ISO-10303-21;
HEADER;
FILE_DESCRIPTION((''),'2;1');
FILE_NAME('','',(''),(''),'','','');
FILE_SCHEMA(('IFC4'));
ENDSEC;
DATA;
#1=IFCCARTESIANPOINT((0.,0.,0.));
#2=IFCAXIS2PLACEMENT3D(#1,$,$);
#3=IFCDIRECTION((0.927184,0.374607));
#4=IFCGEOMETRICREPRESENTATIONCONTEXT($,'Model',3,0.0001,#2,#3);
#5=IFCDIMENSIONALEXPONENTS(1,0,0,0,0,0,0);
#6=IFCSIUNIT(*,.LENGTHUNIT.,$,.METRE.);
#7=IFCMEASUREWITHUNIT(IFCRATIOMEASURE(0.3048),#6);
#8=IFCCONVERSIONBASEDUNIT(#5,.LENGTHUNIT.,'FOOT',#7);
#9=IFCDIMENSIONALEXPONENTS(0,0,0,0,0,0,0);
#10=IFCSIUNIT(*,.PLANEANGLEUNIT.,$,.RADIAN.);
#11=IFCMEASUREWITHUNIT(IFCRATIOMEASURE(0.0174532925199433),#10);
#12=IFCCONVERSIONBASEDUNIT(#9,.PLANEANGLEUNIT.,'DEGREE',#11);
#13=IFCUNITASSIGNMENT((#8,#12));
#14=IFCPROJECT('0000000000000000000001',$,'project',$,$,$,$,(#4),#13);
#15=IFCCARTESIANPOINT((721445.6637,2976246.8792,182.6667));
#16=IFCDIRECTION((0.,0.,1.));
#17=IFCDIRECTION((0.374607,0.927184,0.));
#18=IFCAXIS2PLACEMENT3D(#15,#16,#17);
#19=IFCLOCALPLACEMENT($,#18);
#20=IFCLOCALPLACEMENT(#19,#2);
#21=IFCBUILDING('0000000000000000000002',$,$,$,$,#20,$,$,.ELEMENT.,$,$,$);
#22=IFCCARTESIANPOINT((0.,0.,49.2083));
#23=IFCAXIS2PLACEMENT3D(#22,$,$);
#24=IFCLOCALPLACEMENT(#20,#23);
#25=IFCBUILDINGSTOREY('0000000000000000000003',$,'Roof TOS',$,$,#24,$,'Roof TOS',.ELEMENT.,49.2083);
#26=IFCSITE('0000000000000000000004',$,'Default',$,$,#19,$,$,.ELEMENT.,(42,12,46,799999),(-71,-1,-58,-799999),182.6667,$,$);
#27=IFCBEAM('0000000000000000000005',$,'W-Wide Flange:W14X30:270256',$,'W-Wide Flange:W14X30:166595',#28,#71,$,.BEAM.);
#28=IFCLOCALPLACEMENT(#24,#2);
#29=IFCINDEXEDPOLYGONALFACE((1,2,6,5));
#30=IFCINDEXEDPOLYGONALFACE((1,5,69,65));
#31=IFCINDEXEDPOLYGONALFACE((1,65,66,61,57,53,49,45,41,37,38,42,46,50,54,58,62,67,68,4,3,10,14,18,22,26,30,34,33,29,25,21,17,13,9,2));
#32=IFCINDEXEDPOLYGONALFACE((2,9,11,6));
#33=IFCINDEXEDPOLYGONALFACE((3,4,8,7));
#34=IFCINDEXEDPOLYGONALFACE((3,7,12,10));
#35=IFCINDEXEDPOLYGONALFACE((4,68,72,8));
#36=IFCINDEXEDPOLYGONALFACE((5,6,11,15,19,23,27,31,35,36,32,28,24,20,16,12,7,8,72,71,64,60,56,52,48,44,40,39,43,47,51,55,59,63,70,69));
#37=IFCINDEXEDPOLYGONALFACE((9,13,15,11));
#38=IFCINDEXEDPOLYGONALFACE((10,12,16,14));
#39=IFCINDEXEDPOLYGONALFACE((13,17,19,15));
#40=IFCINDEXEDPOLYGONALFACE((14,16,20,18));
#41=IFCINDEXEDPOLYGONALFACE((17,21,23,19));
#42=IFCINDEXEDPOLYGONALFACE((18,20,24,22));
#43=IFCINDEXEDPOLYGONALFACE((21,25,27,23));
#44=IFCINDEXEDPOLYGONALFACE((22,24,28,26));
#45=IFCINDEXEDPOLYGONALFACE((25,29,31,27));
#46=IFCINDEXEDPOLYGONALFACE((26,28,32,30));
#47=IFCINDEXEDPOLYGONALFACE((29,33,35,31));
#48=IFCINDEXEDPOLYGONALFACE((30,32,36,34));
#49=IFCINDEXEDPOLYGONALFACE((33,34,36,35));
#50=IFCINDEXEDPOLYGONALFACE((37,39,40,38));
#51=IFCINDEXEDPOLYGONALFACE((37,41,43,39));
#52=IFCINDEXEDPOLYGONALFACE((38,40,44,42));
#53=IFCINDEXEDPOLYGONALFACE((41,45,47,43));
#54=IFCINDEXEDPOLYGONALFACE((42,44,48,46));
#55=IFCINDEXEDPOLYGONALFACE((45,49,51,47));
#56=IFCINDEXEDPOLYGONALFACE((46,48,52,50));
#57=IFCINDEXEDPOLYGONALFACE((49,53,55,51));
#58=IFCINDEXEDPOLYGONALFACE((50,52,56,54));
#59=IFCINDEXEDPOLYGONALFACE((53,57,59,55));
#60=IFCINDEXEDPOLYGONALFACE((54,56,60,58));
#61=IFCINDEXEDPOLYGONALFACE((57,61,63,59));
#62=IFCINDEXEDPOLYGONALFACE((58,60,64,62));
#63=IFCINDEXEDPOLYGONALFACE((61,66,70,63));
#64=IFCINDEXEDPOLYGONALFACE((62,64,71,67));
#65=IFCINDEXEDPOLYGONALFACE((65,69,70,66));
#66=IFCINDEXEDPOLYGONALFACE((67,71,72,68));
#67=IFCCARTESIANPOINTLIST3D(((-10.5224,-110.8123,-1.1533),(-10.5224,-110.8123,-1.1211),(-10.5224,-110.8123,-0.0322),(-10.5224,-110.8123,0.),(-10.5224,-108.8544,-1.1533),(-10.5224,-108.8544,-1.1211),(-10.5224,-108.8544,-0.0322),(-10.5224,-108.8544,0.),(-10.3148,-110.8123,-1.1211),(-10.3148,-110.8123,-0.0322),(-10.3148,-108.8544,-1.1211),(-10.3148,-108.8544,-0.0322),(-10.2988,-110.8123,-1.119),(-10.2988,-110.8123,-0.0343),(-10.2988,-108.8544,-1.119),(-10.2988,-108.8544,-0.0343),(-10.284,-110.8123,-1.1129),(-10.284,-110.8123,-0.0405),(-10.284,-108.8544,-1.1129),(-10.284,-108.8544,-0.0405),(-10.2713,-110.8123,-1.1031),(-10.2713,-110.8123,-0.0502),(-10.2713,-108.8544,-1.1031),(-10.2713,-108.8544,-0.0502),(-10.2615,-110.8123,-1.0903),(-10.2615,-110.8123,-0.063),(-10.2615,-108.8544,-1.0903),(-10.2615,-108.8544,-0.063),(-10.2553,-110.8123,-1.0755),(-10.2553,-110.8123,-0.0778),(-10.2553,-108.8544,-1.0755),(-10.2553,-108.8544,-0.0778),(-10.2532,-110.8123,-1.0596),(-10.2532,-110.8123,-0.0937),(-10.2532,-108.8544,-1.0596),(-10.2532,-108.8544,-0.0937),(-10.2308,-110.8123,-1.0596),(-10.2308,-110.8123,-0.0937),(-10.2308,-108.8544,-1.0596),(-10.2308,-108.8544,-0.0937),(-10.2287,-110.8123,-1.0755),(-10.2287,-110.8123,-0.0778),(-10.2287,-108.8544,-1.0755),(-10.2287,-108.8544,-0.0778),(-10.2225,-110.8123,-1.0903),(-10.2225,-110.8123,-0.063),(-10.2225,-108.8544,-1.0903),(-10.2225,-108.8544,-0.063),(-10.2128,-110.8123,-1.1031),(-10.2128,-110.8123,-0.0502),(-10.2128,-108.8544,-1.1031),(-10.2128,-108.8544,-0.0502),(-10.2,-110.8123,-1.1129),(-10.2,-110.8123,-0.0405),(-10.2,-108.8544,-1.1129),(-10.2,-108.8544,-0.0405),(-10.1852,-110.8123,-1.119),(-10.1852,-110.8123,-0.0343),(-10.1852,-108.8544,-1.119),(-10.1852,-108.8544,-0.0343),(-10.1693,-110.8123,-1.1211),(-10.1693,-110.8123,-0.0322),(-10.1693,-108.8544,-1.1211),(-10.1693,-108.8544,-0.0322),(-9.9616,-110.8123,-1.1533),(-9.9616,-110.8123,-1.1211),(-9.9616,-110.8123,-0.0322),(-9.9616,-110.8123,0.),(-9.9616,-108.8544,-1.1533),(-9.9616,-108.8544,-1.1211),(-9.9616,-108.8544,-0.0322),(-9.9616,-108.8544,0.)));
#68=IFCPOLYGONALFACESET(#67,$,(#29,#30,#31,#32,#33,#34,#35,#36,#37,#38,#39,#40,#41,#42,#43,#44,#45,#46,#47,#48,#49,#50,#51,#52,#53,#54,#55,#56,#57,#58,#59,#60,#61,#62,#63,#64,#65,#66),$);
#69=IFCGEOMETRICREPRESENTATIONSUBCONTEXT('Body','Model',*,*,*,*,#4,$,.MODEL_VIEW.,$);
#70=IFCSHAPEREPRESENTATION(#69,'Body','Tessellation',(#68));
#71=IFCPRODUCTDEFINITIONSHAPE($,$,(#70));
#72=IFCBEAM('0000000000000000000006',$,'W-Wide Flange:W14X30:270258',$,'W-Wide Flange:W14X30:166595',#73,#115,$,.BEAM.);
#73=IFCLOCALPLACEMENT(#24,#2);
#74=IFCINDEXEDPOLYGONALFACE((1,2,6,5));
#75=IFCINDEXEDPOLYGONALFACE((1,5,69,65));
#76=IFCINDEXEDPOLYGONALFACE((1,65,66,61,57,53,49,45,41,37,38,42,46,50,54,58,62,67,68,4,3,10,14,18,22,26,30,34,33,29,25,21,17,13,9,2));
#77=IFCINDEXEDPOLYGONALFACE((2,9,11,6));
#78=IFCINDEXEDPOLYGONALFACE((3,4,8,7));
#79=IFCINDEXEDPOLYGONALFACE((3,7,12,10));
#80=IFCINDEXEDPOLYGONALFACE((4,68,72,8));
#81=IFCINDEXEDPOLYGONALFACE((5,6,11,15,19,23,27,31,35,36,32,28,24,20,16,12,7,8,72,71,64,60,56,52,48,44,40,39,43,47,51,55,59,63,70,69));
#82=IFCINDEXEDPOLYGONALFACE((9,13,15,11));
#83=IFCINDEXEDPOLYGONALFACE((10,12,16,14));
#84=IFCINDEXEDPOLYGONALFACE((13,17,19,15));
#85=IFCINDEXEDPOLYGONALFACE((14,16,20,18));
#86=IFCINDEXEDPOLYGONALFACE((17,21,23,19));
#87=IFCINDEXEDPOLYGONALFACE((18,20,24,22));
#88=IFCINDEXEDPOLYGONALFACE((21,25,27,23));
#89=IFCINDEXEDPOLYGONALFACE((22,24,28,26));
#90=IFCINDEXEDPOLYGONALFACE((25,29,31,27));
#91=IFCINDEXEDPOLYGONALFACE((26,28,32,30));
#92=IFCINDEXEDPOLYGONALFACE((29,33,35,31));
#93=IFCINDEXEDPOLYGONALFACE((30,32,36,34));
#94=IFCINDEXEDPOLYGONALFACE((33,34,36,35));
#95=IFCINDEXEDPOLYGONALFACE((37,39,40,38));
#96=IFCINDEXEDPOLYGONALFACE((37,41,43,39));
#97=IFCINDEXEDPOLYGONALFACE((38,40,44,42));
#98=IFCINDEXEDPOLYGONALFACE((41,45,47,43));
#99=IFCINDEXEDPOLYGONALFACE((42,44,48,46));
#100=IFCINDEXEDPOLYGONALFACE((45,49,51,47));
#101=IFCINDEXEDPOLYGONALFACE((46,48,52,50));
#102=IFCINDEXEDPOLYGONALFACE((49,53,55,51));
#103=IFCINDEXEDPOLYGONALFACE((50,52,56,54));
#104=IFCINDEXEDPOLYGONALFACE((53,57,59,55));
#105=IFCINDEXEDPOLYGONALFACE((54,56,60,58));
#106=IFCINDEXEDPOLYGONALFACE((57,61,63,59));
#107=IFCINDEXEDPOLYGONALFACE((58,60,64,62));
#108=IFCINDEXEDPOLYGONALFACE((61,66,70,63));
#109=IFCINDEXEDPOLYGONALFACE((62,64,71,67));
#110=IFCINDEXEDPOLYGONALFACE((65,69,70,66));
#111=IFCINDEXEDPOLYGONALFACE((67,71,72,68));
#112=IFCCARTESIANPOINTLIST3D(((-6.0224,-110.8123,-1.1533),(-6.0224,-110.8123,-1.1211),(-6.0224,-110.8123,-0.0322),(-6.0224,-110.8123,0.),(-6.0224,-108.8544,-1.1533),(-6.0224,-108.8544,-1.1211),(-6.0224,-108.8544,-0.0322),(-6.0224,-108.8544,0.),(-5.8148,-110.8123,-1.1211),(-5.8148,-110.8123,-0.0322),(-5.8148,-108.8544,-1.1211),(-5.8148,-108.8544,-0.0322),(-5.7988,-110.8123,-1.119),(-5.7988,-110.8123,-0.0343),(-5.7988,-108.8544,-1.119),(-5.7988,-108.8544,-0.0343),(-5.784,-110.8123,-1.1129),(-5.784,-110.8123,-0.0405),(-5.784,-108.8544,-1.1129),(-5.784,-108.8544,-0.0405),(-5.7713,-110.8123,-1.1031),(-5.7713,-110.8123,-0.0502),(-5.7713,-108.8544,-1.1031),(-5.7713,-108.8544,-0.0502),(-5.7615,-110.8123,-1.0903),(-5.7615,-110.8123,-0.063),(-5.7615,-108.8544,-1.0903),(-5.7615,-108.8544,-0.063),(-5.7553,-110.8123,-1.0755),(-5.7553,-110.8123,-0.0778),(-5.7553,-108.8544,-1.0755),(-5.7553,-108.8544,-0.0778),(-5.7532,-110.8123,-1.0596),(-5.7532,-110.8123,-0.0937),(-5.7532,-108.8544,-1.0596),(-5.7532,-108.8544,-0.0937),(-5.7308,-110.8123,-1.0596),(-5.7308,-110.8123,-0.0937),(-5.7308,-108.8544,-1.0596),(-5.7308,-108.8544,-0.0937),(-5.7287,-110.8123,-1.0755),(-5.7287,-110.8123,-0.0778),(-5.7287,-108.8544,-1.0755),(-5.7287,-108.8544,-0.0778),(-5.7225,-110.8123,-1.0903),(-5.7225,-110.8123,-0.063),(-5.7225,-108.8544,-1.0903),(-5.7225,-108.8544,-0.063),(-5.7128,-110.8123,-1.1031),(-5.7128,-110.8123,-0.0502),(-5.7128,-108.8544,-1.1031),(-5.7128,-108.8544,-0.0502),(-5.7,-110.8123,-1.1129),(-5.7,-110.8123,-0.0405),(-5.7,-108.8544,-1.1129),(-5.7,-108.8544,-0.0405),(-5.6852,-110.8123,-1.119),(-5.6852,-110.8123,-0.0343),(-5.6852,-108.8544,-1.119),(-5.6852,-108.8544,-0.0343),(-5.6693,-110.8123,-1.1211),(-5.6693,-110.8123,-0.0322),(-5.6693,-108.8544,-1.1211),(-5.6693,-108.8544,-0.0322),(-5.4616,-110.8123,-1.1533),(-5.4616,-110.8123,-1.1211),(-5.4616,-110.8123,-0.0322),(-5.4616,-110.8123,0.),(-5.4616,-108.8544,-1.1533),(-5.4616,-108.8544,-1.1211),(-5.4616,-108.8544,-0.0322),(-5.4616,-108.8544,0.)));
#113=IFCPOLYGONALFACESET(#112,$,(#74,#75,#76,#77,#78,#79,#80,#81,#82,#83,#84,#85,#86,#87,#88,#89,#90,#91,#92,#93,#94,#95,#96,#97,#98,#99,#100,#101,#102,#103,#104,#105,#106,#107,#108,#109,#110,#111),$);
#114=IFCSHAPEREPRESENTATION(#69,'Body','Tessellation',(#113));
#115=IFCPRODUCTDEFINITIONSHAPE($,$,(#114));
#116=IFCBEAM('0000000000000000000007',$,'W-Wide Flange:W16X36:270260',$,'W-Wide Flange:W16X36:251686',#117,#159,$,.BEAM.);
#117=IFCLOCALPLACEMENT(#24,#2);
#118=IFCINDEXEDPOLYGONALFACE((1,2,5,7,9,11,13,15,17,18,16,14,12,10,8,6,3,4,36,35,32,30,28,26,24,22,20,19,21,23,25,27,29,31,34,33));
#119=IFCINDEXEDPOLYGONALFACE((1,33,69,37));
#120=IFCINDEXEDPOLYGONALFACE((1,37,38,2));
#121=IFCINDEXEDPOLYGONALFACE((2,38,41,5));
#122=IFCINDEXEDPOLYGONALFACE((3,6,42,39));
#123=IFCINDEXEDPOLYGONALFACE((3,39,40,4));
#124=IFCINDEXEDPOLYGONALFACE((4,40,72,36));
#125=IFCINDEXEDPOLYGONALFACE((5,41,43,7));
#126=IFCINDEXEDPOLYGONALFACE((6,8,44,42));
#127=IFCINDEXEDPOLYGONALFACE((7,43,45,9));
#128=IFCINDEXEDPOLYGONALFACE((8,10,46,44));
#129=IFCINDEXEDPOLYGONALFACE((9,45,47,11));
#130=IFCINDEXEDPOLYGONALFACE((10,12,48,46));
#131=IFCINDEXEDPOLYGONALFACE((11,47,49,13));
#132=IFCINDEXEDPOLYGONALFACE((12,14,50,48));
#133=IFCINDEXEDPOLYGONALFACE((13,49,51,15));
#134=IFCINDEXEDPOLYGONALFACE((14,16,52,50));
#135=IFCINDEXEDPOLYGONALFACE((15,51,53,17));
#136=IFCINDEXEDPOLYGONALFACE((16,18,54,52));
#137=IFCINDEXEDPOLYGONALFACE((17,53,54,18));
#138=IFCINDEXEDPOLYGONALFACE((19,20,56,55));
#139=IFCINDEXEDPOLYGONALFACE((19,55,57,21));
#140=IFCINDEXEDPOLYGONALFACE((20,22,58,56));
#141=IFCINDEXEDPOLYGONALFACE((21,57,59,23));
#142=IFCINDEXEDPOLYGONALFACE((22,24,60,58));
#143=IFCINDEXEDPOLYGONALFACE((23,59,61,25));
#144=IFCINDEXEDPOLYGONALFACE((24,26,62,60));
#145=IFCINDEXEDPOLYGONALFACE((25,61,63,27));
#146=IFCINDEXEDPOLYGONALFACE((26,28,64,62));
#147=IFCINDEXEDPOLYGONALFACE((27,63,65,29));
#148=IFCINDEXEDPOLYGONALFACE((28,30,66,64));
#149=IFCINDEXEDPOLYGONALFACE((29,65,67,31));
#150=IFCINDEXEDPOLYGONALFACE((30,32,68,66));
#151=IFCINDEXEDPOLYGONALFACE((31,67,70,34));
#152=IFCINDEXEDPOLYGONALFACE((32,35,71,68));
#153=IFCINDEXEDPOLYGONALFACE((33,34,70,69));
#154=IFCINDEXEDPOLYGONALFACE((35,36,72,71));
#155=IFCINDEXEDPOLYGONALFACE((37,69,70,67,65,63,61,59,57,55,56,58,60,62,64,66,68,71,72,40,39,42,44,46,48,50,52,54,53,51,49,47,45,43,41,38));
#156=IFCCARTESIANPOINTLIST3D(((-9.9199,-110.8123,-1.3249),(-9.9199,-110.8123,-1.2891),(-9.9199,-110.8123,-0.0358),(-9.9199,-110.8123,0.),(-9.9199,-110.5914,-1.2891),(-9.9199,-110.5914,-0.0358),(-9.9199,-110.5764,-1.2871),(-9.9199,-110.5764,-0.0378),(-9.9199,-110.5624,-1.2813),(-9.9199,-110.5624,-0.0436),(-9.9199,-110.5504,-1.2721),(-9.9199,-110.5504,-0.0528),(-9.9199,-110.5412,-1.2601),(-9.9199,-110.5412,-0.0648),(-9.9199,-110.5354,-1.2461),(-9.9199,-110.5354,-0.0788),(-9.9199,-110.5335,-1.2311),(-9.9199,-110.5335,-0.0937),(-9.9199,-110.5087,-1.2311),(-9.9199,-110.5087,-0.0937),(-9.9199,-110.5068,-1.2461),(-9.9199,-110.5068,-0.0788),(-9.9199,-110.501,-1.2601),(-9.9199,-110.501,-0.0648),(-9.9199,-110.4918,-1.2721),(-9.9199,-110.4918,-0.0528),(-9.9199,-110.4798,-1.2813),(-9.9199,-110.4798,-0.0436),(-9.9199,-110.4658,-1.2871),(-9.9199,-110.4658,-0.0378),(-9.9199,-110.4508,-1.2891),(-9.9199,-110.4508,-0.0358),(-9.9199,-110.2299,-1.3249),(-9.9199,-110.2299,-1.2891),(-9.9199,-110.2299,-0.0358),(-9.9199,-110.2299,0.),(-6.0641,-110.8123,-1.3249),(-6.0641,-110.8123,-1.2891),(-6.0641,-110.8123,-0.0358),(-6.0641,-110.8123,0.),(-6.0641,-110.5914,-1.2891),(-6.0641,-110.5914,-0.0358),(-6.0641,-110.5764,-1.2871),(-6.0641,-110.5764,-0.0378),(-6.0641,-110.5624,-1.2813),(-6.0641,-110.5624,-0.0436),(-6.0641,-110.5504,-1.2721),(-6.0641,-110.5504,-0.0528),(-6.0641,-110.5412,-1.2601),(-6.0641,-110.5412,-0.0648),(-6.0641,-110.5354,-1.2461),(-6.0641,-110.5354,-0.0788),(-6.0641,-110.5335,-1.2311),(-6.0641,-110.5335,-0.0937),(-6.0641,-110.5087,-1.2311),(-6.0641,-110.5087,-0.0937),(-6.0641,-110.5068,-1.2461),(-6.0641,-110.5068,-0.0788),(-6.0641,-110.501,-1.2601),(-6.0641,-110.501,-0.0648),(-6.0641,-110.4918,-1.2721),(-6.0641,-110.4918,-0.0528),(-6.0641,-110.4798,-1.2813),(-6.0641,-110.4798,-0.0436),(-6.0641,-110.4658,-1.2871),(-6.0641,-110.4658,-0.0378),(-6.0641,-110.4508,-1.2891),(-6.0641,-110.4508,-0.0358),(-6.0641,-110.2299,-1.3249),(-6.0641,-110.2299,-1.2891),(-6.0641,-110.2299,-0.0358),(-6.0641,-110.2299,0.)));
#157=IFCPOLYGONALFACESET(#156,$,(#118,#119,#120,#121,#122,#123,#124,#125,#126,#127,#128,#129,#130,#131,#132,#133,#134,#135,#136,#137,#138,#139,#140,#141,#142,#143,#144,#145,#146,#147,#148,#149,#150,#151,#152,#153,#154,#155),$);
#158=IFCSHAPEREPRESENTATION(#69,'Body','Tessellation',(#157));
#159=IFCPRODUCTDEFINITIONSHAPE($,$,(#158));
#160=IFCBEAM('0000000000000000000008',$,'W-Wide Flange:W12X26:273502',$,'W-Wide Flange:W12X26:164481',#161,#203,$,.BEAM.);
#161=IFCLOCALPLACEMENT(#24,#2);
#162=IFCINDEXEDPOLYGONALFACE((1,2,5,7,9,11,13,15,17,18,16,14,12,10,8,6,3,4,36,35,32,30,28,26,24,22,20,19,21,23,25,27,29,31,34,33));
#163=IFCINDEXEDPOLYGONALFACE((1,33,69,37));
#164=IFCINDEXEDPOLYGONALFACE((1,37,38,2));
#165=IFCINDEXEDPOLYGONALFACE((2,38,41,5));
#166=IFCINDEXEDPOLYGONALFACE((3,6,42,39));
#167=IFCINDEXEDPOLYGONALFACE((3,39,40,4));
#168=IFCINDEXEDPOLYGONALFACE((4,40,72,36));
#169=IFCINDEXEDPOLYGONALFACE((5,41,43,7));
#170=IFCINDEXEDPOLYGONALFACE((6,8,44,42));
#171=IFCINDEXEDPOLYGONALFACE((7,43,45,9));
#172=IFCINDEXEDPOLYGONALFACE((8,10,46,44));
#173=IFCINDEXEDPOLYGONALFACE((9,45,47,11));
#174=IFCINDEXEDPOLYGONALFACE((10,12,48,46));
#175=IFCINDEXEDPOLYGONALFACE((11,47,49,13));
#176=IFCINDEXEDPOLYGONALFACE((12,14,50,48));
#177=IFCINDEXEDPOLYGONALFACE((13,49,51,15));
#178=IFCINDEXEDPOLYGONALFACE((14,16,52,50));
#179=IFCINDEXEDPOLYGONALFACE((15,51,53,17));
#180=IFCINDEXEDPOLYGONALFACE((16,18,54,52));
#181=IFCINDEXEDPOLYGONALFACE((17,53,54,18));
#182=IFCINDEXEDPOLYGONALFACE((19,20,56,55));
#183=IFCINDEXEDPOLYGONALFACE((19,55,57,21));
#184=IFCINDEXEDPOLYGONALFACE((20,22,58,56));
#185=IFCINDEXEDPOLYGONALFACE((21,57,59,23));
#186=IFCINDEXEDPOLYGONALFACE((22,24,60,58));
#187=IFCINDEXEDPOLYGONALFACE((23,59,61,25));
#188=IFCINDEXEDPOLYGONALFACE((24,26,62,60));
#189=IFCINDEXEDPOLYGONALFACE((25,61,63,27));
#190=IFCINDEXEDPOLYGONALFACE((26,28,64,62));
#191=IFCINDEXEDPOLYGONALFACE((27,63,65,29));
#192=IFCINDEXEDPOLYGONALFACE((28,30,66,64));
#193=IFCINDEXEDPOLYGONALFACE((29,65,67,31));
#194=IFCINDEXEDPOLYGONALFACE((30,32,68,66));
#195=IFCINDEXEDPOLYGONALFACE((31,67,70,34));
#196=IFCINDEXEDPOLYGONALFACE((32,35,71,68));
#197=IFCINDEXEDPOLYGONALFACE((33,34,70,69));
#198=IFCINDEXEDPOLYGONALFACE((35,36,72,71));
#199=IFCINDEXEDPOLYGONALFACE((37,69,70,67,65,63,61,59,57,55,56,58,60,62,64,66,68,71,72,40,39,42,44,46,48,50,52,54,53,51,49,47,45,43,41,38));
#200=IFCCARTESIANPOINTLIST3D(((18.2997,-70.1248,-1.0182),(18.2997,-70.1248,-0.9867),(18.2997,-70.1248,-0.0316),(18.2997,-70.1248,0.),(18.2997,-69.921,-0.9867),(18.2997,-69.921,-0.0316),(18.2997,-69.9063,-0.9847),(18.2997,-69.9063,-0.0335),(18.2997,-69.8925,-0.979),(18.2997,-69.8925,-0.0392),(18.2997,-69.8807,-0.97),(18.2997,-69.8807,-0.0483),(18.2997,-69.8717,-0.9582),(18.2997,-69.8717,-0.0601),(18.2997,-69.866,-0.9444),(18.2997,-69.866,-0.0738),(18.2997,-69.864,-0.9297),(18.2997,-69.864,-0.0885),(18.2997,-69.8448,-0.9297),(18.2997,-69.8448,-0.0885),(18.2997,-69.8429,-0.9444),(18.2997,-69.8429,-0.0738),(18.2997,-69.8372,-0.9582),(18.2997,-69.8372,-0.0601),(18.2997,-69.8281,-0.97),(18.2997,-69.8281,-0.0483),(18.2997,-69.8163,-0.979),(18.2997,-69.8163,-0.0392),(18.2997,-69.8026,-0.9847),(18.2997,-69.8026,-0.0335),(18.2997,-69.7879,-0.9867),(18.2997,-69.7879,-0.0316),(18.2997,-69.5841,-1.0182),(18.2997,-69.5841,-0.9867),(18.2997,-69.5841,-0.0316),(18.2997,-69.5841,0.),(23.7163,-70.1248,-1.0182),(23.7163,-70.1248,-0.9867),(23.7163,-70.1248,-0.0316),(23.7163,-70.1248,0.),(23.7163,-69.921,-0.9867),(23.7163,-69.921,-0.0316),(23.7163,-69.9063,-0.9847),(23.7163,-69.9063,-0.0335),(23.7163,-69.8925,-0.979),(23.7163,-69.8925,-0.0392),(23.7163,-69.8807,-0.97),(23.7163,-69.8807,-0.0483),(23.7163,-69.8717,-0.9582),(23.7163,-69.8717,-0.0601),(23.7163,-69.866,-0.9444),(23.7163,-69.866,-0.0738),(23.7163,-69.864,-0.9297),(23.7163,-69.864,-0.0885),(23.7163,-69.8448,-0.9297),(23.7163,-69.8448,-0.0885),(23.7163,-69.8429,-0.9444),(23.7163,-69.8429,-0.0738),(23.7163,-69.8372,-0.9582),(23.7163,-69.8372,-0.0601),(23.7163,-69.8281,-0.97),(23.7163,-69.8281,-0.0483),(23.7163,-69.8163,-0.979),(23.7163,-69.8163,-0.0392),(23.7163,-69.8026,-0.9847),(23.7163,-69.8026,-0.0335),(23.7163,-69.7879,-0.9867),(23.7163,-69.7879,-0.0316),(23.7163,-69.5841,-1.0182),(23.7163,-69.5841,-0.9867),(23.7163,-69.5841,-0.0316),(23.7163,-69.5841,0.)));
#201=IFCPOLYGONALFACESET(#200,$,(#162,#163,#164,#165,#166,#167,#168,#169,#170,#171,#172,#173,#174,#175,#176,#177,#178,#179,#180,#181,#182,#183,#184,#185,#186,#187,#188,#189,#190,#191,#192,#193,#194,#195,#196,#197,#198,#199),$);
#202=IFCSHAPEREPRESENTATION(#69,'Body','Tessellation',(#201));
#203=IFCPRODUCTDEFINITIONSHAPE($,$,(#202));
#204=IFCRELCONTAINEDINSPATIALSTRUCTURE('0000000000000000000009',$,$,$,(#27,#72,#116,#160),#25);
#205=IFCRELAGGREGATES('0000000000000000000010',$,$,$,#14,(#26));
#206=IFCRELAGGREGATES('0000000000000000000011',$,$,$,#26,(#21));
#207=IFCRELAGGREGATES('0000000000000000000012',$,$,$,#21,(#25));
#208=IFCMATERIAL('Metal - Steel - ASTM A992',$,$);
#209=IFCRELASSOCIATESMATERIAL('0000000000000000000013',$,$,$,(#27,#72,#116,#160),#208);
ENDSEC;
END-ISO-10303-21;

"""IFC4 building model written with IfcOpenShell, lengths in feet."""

from ifc_helpers import new_model, entity, si_unit, converted_unit, direction, frame, frame_2d, origin, place, context, subcontext, project, spatial, i_section, extrude, material, element, save


model = new_model("IFC4")

# Units and contexts
model_context = context("Model", 3, precision=0.0001, world=origin(), true_north=direction((0.927184, 0.374607)))
body_context = subcontext(model_context, "Body", "Model", "MODEL_VIEW")
ifc_project = project(units=[converted_unit("LENGTHUNIT", "FOOT", entity("IfcRatioMeasure", 0.3048), si_unit("LENGTHUNIT", "METRE"), dimensions=[1, 0, 0, 0, 0, 0, 0]), converted_unit("PLANEANGLEUNIT", "DEGREE", entity("IfcRatioMeasure", 0.0174532925199433), si_unit("PLANEANGLEUNIT", "RADIAN"), dimensions=[0, 0, 0, 0, 0, 0, 0])], contexts=[model_context])

# Site, building, storey
site_placement = place(None, frame((721445.6637, 2976246.8792, 182.6667), z_axis=(0.0, 0.0, 1.0), x_axis=(0.374607, 0.927184, 0.0)))
site = spatial("IfcSite", under=ifc_project, at=site_placement, Name="Default", CompositionType="ELEMENT", RefLatitude=(42, 12, 46, 799999), RefLongitude=(-71, -1, -58, -799999), RefElevation=182.6667)
building_placement = place(site_placement, origin())
building = spatial("IfcBuilding", under=site, at=building_placement, CompositionType="ELEMENT")
storey_placement = place(building_placement, frame((0.0, 0.0, 49.2083)))
storey = spatial("IfcBuildingStorey", under=building, at=storey_placement, Name="Roof TOS", LongName="Roof TOS", CompositionType="ELEMENT", Elevation=49.2083)

# Beams
ifc_material = material(Name="Metal - Steel - ASTM A992")
beam_1_placement = place(storey_placement, frame((-10.242, -108.5211, 0.0), z_axis=(0.0, 0.0, 1.0), x_axis=(0.0, -1.0, 0.0)))
element("IfcBeam", 1, at=beam_1_placement, inside=storey, material=ifc_material, Name="W-Wide Flange:W14X30:270256", ObjectType="W-Wide Flange:W14X30:166595", PredefinedType="BEAM", context=body_context, shape_type="SweptSolid", body=[
    extrude(i_section(OverallWidth=0.5609, OverallDepth=1.1533, WebThickness=0.0225, FlangeThickness=0.0322, FilletRadius=0.0615, at=frame_2d((0.0, 0.0), x_axis=(0.0, 1.0))), frame((0.3333, 0.0, -0.5767), z_axis=(1.0, 0.0, 0.0), x_axis=(0.0, 0.0, -1.0)), (0.0, 0.0, 1.0), 1.9578),
])
beam_2_placement = place(storey_placement, frame((-5.742, -108.5211, 0.0), z_axis=(0.0, 0.0, 1.0), x_axis=(0.0, -1.0, 0.0)))
element("IfcBeam", 2, at=beam_2_placement, inside=storey, material=ifc_material, Name="W-Wide Flange:W14X30:270258", ObjectType="W-Wide Flange:W14X30:166595", PredefinedType="BEAM", context=body_context, shape_type="SweptSolid", body=[
    extrude(i_section(OverallWidth=0.5609, OverallDepth=1.1533, WebThickness=0.0225, FlangeThickness=0.0322, FilletRadius=0.0615, at=frame_2d((0.0, 0.0), x_axis=(0.0, 1.0))), frame((0.3333, 0.0, -0.5767), z_axis=(1.0, 0.0, 0.0), x_axis=(0.0, 0.0, -1.0)), (0.0, 0.0, 1.0), 1.9578),
])
beam_3_placement = place(storey_placement, frame((-10.242, -110.5211, 0.0)))
element("IfcBeam", 3, at=beam_3_placement, inside=storey, material=ifc_material, Name="W-Wide Flange:W16X36:270260", ObjectType="W-Wide Flange:W16X36:251686", PredefinedType="BEAM", context=body_context, shape_type="SweptSolid", body=[
    extrude(i_section(OverallWidth=0.5824, OverallDepth=1.3249, WebThickness=0.0247, FlangeThickness=0.0358, FilletRadius=0.0579, at=frame_2d((0.0, 0.0), x_axis=(0.0, 1.0))), frame((0.3221, 0.0, -0.6624), z_axis=(1.0, 0.0, 0.0), x_axis=(0.0, 0.0, -1.0)), (0.0, 0.0, 1.0), 3.8558),
])
beam_4_placement = place(storey_placement, frame((18.008, -69.8544, 0.0)))
element("IfcBeam", 4, at=beam_4_placement, inside=storey, material=ifc_material, Name="W-Wide Flange:W12X26:273502", ObjectType="W-Wide Flange:W12X26:164481", PredefinedType="BEAM", context=body_context, shape_type="SweptSolid", body=[
    extrude(i_section(OverallWidth=0.5407, OverallDepth=1.0182, WebThickness=0.0192, FlangeThickness=0.0316, FilletRadius=0.057, at=frame_2d((0.0, 0.0), x_axis=(0.0, 1.0))), frame((0.2917, 0.0, -0.5091), z_axis=(1.0, 0.0, 0.0), x_axis=(0.0, 0.0, -1.0)), (0.0, 0.0, 1.0), 5.4167),
])

save(model, "model.ifc")
